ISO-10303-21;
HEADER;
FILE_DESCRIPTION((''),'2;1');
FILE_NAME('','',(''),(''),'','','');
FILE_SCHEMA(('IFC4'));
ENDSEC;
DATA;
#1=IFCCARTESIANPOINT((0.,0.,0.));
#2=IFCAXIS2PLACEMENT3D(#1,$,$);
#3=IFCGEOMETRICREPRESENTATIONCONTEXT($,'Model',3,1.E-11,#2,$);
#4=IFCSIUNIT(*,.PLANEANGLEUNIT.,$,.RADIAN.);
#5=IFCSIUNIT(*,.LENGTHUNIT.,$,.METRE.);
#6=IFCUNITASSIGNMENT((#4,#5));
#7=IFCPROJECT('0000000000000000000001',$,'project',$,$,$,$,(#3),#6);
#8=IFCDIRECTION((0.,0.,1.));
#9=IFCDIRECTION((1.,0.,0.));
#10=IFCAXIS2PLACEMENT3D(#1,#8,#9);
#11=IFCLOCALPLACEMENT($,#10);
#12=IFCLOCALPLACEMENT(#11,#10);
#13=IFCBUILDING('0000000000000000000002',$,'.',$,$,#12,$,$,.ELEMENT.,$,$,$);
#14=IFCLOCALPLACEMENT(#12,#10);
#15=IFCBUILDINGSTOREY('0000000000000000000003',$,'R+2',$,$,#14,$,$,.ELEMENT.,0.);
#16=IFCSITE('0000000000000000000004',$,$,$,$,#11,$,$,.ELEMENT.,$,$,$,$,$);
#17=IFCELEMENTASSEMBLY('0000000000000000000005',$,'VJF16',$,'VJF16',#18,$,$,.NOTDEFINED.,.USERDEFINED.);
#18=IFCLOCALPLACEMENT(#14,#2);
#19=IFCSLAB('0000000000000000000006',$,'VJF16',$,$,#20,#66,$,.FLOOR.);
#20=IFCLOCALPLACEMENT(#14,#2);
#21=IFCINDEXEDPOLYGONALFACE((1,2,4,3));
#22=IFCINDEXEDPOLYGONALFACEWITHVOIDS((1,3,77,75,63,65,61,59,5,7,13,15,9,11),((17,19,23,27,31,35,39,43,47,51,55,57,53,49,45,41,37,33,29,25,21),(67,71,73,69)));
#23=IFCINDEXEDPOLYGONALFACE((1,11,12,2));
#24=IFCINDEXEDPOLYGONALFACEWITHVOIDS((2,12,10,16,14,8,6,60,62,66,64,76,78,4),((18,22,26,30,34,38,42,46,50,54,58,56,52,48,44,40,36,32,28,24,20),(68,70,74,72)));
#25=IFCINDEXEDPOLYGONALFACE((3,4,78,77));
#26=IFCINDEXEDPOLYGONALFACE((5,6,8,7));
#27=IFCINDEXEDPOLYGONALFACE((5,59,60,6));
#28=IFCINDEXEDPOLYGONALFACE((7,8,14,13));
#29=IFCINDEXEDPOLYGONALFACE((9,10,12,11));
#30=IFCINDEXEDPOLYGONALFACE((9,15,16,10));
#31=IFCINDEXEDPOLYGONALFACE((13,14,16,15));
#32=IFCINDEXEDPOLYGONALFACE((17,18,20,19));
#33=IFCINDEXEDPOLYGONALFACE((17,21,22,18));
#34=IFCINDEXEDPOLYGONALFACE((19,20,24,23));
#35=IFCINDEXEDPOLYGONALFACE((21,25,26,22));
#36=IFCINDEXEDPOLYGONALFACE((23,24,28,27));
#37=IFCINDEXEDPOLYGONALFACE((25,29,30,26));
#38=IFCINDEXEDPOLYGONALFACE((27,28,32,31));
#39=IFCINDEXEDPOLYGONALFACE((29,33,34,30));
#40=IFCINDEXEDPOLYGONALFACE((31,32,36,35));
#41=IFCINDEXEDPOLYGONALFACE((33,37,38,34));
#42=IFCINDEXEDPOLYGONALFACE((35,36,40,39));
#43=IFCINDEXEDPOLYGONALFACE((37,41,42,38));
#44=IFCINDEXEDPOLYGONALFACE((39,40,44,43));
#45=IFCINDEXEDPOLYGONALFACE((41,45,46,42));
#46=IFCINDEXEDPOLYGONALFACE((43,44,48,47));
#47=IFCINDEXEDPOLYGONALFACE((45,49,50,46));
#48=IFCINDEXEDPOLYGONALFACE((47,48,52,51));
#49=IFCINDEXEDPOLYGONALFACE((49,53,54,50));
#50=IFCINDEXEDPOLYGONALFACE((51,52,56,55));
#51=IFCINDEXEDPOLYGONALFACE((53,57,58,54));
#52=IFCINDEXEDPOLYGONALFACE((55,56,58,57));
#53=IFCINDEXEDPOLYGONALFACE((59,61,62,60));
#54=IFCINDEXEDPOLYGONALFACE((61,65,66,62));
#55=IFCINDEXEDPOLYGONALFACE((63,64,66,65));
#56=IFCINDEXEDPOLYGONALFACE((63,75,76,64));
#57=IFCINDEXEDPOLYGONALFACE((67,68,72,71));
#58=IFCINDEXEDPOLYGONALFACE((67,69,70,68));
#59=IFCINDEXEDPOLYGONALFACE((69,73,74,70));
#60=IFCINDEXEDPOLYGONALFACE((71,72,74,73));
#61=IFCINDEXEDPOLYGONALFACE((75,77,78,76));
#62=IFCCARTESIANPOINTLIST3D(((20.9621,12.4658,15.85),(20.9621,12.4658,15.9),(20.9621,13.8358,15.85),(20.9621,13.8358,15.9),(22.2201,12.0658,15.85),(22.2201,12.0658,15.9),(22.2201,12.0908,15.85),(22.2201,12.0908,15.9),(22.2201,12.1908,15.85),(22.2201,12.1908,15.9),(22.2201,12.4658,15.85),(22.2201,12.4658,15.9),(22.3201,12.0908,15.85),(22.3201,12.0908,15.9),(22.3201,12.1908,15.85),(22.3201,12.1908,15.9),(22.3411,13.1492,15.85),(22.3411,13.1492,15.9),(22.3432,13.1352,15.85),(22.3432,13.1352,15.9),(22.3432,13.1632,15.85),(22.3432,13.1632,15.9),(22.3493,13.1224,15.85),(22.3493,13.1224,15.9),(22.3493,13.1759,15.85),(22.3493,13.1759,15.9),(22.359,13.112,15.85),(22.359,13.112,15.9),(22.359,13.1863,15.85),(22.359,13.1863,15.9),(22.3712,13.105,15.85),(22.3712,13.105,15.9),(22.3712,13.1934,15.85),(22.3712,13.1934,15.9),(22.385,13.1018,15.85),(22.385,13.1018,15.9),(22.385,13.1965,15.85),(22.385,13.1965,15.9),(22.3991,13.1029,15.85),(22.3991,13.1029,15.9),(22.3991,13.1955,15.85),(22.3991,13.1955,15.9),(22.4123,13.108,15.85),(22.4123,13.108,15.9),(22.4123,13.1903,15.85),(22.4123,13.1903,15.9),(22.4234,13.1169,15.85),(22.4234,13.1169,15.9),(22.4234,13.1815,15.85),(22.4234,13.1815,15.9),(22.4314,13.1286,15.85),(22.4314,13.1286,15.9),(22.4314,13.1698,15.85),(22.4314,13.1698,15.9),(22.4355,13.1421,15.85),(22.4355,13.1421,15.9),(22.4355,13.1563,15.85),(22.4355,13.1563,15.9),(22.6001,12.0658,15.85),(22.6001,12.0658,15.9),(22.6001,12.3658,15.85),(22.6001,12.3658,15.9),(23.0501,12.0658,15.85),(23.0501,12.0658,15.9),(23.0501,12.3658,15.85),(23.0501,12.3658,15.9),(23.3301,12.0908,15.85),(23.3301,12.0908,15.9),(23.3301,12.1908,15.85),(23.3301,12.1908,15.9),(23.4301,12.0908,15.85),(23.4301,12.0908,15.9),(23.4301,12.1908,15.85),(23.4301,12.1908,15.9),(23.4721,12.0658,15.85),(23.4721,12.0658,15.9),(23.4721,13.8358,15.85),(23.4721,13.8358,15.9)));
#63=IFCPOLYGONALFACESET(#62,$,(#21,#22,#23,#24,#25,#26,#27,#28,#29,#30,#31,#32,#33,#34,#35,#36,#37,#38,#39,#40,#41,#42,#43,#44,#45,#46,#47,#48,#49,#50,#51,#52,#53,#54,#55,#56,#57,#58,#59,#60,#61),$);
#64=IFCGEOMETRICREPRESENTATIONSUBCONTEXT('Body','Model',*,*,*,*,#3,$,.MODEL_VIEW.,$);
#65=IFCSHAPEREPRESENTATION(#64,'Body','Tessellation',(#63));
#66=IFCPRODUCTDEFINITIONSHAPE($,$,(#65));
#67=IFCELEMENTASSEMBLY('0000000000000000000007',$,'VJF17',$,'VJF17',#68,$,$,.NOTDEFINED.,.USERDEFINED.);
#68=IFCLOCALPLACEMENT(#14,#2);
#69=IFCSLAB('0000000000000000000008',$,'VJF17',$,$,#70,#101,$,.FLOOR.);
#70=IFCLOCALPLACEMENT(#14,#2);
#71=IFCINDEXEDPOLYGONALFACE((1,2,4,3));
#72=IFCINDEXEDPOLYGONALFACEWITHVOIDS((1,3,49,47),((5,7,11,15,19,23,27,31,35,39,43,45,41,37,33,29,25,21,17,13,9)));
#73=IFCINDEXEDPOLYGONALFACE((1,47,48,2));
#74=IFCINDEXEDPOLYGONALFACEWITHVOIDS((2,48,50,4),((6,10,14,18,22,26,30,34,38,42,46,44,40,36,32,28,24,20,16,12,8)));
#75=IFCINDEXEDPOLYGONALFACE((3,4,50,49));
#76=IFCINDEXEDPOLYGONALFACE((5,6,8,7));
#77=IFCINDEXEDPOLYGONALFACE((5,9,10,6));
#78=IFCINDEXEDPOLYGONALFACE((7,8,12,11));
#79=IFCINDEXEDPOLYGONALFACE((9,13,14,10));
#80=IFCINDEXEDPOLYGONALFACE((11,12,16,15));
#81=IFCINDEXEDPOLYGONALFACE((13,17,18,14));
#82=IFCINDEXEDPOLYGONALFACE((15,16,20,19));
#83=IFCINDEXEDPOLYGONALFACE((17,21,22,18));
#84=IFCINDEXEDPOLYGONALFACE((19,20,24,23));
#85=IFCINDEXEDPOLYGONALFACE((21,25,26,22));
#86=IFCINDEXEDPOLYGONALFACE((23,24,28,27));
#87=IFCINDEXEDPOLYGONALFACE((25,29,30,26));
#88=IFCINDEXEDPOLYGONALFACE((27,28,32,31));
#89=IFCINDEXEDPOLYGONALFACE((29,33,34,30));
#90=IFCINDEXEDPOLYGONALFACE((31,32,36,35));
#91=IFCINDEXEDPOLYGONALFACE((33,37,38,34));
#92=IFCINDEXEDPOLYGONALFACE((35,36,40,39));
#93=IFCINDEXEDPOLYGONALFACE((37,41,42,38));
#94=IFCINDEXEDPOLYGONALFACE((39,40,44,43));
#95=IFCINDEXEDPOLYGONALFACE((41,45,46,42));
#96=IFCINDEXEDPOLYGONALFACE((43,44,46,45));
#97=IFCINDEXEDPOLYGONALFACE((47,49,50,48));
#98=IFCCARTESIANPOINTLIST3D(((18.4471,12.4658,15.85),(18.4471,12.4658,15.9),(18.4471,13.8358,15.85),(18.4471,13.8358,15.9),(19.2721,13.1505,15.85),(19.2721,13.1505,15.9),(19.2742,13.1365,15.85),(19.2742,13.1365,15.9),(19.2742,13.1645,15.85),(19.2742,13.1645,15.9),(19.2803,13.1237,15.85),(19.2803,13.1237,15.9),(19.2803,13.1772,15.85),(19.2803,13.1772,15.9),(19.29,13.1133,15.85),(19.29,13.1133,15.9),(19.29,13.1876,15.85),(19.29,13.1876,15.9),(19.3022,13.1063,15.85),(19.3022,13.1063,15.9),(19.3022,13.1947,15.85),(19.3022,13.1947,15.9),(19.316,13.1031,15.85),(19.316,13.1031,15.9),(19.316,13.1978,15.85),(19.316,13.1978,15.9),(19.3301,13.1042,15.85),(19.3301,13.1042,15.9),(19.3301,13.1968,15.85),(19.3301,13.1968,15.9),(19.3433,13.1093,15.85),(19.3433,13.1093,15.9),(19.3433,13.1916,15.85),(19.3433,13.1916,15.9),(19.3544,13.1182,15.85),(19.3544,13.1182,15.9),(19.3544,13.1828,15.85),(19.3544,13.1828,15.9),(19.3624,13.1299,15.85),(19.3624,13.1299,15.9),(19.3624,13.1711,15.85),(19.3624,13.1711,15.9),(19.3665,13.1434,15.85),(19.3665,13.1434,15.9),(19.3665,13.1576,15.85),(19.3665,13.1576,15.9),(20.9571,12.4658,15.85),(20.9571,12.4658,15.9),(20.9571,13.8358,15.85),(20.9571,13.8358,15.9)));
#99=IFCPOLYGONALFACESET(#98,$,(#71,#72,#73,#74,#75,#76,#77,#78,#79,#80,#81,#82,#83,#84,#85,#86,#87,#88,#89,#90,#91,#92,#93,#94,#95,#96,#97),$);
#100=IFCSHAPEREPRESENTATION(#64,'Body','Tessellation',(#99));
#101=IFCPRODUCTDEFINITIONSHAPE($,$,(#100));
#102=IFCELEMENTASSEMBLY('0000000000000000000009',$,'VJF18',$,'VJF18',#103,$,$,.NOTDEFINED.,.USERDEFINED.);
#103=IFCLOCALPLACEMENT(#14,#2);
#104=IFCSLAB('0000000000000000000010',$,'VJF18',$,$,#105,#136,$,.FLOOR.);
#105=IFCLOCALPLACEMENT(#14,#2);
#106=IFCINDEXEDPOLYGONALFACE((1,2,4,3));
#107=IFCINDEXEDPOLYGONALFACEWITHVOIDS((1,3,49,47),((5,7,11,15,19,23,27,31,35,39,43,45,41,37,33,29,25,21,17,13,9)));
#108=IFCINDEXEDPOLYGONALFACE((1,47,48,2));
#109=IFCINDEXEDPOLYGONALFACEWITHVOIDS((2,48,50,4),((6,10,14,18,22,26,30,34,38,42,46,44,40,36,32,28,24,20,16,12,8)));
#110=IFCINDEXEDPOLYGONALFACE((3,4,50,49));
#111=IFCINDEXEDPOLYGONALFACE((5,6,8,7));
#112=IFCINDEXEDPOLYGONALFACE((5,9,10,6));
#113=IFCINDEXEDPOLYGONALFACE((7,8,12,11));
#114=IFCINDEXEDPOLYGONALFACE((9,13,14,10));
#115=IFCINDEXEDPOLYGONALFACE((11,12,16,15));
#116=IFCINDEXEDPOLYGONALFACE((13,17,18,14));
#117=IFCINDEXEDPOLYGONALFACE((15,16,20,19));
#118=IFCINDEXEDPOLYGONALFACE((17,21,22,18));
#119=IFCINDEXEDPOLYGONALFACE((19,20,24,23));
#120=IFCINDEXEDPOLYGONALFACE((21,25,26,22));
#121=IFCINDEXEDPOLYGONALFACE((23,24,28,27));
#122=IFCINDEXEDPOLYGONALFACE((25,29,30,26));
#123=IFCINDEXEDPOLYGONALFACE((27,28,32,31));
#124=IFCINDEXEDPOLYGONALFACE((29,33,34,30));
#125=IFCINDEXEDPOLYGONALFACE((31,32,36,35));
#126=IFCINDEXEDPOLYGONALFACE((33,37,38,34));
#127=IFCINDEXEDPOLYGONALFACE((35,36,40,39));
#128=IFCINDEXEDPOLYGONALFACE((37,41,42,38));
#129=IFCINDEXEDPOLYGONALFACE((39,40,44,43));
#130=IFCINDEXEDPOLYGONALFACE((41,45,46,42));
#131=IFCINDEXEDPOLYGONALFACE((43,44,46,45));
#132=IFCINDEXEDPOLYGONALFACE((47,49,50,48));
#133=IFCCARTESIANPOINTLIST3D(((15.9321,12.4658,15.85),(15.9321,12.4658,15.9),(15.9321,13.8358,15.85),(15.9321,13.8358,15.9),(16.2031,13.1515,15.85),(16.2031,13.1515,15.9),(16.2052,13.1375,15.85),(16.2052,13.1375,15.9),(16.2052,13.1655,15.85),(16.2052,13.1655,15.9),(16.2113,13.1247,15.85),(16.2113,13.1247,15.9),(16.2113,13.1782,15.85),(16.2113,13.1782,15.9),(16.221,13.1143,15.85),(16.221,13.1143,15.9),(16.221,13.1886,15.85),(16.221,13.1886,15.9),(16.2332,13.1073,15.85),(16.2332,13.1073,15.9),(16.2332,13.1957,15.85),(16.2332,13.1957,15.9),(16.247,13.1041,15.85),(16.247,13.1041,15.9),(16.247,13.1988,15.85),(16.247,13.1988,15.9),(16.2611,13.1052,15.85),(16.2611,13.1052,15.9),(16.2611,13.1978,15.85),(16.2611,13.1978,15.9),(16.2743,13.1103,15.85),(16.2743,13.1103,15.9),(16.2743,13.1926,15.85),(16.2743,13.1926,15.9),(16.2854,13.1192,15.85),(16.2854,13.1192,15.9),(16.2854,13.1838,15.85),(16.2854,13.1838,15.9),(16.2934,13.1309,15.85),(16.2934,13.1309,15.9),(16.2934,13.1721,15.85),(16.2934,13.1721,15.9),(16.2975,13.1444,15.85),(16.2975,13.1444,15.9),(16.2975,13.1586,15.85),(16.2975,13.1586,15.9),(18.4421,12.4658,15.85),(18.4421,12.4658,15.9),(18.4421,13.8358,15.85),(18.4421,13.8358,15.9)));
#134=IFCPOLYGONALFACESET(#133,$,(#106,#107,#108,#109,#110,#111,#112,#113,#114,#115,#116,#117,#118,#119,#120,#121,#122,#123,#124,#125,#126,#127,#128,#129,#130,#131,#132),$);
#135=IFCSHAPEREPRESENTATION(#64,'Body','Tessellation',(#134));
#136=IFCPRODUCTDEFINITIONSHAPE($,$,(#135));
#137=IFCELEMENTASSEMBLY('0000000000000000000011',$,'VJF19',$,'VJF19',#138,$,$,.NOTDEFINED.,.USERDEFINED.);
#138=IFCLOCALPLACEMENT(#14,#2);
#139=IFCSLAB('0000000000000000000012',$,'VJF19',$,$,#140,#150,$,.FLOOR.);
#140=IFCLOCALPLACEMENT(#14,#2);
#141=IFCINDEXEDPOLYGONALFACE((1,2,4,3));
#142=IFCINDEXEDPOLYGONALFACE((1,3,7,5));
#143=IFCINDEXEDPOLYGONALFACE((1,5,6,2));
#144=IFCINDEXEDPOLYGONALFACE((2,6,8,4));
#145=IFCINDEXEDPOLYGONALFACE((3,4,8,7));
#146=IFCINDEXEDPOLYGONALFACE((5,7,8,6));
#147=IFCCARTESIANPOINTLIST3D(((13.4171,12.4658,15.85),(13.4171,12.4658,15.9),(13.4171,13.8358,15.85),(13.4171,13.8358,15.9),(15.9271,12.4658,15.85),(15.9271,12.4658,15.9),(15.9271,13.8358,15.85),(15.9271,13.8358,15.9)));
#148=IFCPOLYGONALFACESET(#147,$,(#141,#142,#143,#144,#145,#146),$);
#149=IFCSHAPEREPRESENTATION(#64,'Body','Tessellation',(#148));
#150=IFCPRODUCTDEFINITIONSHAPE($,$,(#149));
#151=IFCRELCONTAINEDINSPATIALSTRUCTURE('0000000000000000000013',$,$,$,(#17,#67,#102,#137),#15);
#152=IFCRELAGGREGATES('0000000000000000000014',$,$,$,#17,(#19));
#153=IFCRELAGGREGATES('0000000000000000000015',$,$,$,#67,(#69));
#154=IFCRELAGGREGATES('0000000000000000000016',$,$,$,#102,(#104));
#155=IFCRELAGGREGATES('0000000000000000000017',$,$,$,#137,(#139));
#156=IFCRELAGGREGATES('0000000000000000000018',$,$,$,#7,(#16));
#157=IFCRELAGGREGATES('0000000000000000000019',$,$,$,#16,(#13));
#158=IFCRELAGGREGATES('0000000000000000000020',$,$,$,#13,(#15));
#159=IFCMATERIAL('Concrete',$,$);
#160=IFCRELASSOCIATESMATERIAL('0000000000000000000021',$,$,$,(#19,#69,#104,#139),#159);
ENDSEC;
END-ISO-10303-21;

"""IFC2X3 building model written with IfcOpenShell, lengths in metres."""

from ifc_helpers import new_model, si_unit, frame, origin, origin_with_axes, origin_2d_with_axis, place, context, subcontext, project, spatial, polyline, circle, outline, extrude, material, element, aggregate, save


model = new_model("IFC2X3")

# Units and contexts
model_context = context("Model", 3, precision=1e-11, world=origin())
body_context = subcontext(model_context, "Body", "Model", "MODEL_VIEW")
ifc_project = project(units=[si_unit("PLANEANGLEUNIT", "RADIAN"), si_unit("LENGTHUNIT", "METRE")], contexts=[model_context])

# Site, building, storey
site_placement = place(None, origin_with_axes())
site = spatial("IfcSite", under=ifc_project, at=site_placement, CompositionType="ELEMENT")
building_placement = place(site_placement, origin_with_axes())
building = spatial("IfcBuilding", under=site, at=building_placement, Name=".", CompositionType="ELEMENT")
storey_placement = place(building_placement, origin_with_axes())
storey = spatial("IfcBuildingStorey", under=building, at=storey_placement, Name="R+2", CompositionType="ELEMENT", Elevation=0.0)

# Element assembly, slab, openings
assembly_1_placement = place(storey_placement, origin_with_axes())
assembly_1 = element("IfcElementAssembly", 1, at=assembly_1_placement, inside=storey, Name="VJF16", ObjectType="VJF16", AssemblyPlace="NOTDEFINED", PredefinedType="USERDEFINED")
ifc_material = material(Name="Concrete")
slab_1_placement = place(assembly_1_placement, frame((23.4721, 12.0658, 15.85), z_axis=(0.0, 0.0, 1.0), x_axis=(0.0, 1.0, 0.0)))
slab_1 = element("IfcSlab", 2, at=slab_1_placement, material=ifc_material, Name="VJF16", PredefinedType="FLOOR", context=body_context, shape_type="SweptSolid", body=[
    extrude(outline(polyline([(0.0, 0.0), (0.0, -1.77), (2.51, -1.77), (2.51, -0.4), (1.252, -0.4), (1.252, 0.0), (0.0, 0.0)])), frame((0.0, 0.0, 0.0), z_axis=(0.0, 0.0, 1.0), x_axis=(0.0, 1.0, 0.0)), (0.0, 0.0, 1.0), 0.05),
])
opening_1_placement = place(slab_1_placement, origin_with_axes())
element("IfcOpeningElement", 3, at=opening_1_placement, cuts=slab_1, ObjectType="Opening", context=body_context, shape_type="SweptSolid", body=[
    extrude(outline(polyline([(0.422, 0.0), (0.422, -0.3), (0.872, -0.3), (0.872, 0.0), (0.422, 0.0)])), frame((0.0, 0.0, 0.0), z_axis=(0.0, 0.0, 1.0), x_axis=(0.0, 1.0, 0.0)), (0.0, 0.0, 1.0), 0.05),
])
opening_2_placement = place(slab_1_placement, frame((1.0834, 1.0835, 0.0), z_axis=(0.0, 0.0, 1.0), x_axis=(1.0, 0.0, 0.0)))
element("IfcOpeningElement", 4, at=opening_2_placement, cuts=slab_1, ObjectType="Opening", context=body_context, shape_type="SweptSolid", body=[
    extrude(circle(Radius=0.0475, at=origin_2d_with_axis()), frame((0.0, 0.0, 0.0), z_axis=(0.0, 0.0, 1.0), x_axis=(0.0, 1.0, 0.0)), (0.0, 0.0, 1.0), 0.05),
])
opening_3_placement = place(slab_1_placement, origin_with_axes())
element("IfcOpeningElement", 5, at=opening_3_placement, cuts=slab_1, ObjectType="Opening", context=body_context, shape_type="SweptSolid", body=[
    extrude(outline(polyline([(0.042, -0.025), (0.042, -0.125), (0.142, -0.125), (0.142, -0.025), (0.042, -0.025)])), frame((0.0, 0.0, 0.0), z_axis=(0.0, 0.0, 1.0), x_axis=(0.0, 1.0, 0.0)), (0.0, 0.0, 1.0), 0.05),
])
opening_4_placement = place(slab_1_placement, origin_with_axes())
element("IfcOpeningElement", 6, at=opening_4_placement, cuts=slab_1, ObjectType="Opening", context=body_context, shape_type="SweptSolid", body=[
    extrude(outline(polyline([(1.152, -0.025), (1.152, -0.125), (1.252, -0.125), (1.252, -0.025), (1.152, -0.025)])), frame((0.0, 0.0, 0.0), z_axis=(0.0, 0.0, 1.0), x_axis=(0.0, 1.0, 0.0)), (0.0, 0.0, 1.0), 0.05),
])

# Element assemblies, slabs, openings
assembly_2_placement = place(storey_placement, origin_with_axes())
assembly_2 = element("IfcElementAssembly", 7, at=assembly_2_placement, inside=storey, Name="VJF17", ObjectType="VJF17", AssemblyPlace="NOTDEFINED", PredefinedType="USERDEFINED")
slab_2_placement = place(assembly_2_placement, frame((20.9571, 12.4658, 15.85), z_axis=(0.0, 0.0, 1.0), x_axis=(0.0, 1.0, 0.0)))
slab_2 = element("IfcSlab", 8, at=slab_2_placement, material=ifc_material, Name="VJF17", PredefinedType="FLOOR", context=body_context, shape_type="SweptSolid", body=[
    extrude(outline(polyline([(0.0, 0.0), (0.0, -1.37), (2.51, -1.37), (2.51, 0.0), (0.0, 0.0)])), frame((0.0, 0.0, 0.0), z_axis=(0.0, 0.0, 1.0), x_axis=(0.0, 1.0, 0.0)), (0.0, 0.0, 1.0), 0.05),
])
opening_5_placement = place(slab_2_placement, frame((0.6847, 1.6375, 0.0), z_axis=(0.0, 0.0, 1.0), x_axis=(1.0, 0.0, 0.0)))
element("IfcOpeningElement", 9, at=opening_5_placement, cuts=slab_2, ObjectType="Opening", context=body_context, shape_type="SweptSolid", body=[
    extrude(circle(Radius=0.0475, at=origin_2d_with_axis()), frame((0.0, 0.0, 0.0), z_axis=(0.0, 0.0, 1.0), x_axis=(0.0, 1.0, 0.0)), (0.0, 0.0, 1.0), 0.05),
])
assembly_3_placement = place(storey_placement, origin_with_axes())
assembly_3 = element("IfcElementAssembly", 10, at=assembly_3_placement, inside=storey, Name="VJF18", ObjectType="VJF18", AssemblyPlace="NOTDEFINED", PredefinedType="USERDEFINED")
slab_3_placement = place(assembly_3_placement, frame((18.4421, 12.4658, 15.85), z_axis=(0.0, 0.0, 1.0), x_axis=(0.0, 1.0, 0.0)))
slab_3 = element("IfcSlab", 11, at=slab_3_placement, material=ifc_material, Name="VJF18", PredefinedType="FLOOR", context=body_context, shape_type="SweptSolid", body=[
    extrude(outline(polyline([(0.0, 0.0), (0.0, -1.37), (2.51, -1.37), (2.51, 0.0), (0.0, 0.0)])), frame((0.0, 0.0, 0.0), z_axis=(0.0, 0.0, 1.0), x_axis=(0.0, 1.0, 0.0)), (0.0, 0.0, 1.0), 0.05),
])
opening_6_placement = place(slab_3_placement, frame((0.6857, 2.1915, 0.0), z_axis=(0.0, 0.0, 1.0), x_axis=(1.0, 0.0, 0.0)))
element("IfcOpeningElement", 12, at=opening_6_placement, cuts=slab_3, ObjectType="Opening", context=body_context, shape_type="SweptSolid", body=[
    extrude(circle(Radius=0.0475, at=origin_2d_with_axis()), frame((0.0, 0.0, 0.0), z_axis=(0.0, 0.0, 1.0), x_axis=(0.0, 1.0, 0.0)), (0.0, 0.0, 1.0), 0.05),
])

# Element assembly, slab
assembly_4_placement = place(storey_placement, origin_with_axes())
assembly_4 = element("IfcElementAssembly", 13, at=assembly_4_placement, inside=storey, Name="VJF19", ObjectType="VJF19", AssemblyPlace="NOTDEFINED", PredefinedType="USERDEFINED")
slab_4_placement = place(assembly_4_placement, frame((15.9271, 12.4658, 15.85), z_axis=(0.0, 0.0, 1.0), x_axis=(0.0, 1.0, 0.0)))
slab_4 = element("IfcSlab", 14, at=slab_4_placement, material=ifc_material, Name="VJF19", PredefinedType="FLOOR", context=body_context, shape_type="SweptSolid", body=[
    extrude(outline(polyline([(0.0, 0.0), (0.0, -1.37), (2.51, -1.37), (2.51, 0.0), (0.0, 0.0)])), frame((0.0, 0.0, 0.0), z_axis=(0.0, 0.0, 1.0), x_axis=(0.0, 1.0, 0.0)), (0.0, 0.0, 1.0), 0.05),
])

aggregate(assembly_1, [slab_1])

aggregate(assembly_2, [slab_2])

aggregate(assembly_3, [slab_3])
aggregate(assembly_4, [slab_4])

save(model, "model.ifc")
